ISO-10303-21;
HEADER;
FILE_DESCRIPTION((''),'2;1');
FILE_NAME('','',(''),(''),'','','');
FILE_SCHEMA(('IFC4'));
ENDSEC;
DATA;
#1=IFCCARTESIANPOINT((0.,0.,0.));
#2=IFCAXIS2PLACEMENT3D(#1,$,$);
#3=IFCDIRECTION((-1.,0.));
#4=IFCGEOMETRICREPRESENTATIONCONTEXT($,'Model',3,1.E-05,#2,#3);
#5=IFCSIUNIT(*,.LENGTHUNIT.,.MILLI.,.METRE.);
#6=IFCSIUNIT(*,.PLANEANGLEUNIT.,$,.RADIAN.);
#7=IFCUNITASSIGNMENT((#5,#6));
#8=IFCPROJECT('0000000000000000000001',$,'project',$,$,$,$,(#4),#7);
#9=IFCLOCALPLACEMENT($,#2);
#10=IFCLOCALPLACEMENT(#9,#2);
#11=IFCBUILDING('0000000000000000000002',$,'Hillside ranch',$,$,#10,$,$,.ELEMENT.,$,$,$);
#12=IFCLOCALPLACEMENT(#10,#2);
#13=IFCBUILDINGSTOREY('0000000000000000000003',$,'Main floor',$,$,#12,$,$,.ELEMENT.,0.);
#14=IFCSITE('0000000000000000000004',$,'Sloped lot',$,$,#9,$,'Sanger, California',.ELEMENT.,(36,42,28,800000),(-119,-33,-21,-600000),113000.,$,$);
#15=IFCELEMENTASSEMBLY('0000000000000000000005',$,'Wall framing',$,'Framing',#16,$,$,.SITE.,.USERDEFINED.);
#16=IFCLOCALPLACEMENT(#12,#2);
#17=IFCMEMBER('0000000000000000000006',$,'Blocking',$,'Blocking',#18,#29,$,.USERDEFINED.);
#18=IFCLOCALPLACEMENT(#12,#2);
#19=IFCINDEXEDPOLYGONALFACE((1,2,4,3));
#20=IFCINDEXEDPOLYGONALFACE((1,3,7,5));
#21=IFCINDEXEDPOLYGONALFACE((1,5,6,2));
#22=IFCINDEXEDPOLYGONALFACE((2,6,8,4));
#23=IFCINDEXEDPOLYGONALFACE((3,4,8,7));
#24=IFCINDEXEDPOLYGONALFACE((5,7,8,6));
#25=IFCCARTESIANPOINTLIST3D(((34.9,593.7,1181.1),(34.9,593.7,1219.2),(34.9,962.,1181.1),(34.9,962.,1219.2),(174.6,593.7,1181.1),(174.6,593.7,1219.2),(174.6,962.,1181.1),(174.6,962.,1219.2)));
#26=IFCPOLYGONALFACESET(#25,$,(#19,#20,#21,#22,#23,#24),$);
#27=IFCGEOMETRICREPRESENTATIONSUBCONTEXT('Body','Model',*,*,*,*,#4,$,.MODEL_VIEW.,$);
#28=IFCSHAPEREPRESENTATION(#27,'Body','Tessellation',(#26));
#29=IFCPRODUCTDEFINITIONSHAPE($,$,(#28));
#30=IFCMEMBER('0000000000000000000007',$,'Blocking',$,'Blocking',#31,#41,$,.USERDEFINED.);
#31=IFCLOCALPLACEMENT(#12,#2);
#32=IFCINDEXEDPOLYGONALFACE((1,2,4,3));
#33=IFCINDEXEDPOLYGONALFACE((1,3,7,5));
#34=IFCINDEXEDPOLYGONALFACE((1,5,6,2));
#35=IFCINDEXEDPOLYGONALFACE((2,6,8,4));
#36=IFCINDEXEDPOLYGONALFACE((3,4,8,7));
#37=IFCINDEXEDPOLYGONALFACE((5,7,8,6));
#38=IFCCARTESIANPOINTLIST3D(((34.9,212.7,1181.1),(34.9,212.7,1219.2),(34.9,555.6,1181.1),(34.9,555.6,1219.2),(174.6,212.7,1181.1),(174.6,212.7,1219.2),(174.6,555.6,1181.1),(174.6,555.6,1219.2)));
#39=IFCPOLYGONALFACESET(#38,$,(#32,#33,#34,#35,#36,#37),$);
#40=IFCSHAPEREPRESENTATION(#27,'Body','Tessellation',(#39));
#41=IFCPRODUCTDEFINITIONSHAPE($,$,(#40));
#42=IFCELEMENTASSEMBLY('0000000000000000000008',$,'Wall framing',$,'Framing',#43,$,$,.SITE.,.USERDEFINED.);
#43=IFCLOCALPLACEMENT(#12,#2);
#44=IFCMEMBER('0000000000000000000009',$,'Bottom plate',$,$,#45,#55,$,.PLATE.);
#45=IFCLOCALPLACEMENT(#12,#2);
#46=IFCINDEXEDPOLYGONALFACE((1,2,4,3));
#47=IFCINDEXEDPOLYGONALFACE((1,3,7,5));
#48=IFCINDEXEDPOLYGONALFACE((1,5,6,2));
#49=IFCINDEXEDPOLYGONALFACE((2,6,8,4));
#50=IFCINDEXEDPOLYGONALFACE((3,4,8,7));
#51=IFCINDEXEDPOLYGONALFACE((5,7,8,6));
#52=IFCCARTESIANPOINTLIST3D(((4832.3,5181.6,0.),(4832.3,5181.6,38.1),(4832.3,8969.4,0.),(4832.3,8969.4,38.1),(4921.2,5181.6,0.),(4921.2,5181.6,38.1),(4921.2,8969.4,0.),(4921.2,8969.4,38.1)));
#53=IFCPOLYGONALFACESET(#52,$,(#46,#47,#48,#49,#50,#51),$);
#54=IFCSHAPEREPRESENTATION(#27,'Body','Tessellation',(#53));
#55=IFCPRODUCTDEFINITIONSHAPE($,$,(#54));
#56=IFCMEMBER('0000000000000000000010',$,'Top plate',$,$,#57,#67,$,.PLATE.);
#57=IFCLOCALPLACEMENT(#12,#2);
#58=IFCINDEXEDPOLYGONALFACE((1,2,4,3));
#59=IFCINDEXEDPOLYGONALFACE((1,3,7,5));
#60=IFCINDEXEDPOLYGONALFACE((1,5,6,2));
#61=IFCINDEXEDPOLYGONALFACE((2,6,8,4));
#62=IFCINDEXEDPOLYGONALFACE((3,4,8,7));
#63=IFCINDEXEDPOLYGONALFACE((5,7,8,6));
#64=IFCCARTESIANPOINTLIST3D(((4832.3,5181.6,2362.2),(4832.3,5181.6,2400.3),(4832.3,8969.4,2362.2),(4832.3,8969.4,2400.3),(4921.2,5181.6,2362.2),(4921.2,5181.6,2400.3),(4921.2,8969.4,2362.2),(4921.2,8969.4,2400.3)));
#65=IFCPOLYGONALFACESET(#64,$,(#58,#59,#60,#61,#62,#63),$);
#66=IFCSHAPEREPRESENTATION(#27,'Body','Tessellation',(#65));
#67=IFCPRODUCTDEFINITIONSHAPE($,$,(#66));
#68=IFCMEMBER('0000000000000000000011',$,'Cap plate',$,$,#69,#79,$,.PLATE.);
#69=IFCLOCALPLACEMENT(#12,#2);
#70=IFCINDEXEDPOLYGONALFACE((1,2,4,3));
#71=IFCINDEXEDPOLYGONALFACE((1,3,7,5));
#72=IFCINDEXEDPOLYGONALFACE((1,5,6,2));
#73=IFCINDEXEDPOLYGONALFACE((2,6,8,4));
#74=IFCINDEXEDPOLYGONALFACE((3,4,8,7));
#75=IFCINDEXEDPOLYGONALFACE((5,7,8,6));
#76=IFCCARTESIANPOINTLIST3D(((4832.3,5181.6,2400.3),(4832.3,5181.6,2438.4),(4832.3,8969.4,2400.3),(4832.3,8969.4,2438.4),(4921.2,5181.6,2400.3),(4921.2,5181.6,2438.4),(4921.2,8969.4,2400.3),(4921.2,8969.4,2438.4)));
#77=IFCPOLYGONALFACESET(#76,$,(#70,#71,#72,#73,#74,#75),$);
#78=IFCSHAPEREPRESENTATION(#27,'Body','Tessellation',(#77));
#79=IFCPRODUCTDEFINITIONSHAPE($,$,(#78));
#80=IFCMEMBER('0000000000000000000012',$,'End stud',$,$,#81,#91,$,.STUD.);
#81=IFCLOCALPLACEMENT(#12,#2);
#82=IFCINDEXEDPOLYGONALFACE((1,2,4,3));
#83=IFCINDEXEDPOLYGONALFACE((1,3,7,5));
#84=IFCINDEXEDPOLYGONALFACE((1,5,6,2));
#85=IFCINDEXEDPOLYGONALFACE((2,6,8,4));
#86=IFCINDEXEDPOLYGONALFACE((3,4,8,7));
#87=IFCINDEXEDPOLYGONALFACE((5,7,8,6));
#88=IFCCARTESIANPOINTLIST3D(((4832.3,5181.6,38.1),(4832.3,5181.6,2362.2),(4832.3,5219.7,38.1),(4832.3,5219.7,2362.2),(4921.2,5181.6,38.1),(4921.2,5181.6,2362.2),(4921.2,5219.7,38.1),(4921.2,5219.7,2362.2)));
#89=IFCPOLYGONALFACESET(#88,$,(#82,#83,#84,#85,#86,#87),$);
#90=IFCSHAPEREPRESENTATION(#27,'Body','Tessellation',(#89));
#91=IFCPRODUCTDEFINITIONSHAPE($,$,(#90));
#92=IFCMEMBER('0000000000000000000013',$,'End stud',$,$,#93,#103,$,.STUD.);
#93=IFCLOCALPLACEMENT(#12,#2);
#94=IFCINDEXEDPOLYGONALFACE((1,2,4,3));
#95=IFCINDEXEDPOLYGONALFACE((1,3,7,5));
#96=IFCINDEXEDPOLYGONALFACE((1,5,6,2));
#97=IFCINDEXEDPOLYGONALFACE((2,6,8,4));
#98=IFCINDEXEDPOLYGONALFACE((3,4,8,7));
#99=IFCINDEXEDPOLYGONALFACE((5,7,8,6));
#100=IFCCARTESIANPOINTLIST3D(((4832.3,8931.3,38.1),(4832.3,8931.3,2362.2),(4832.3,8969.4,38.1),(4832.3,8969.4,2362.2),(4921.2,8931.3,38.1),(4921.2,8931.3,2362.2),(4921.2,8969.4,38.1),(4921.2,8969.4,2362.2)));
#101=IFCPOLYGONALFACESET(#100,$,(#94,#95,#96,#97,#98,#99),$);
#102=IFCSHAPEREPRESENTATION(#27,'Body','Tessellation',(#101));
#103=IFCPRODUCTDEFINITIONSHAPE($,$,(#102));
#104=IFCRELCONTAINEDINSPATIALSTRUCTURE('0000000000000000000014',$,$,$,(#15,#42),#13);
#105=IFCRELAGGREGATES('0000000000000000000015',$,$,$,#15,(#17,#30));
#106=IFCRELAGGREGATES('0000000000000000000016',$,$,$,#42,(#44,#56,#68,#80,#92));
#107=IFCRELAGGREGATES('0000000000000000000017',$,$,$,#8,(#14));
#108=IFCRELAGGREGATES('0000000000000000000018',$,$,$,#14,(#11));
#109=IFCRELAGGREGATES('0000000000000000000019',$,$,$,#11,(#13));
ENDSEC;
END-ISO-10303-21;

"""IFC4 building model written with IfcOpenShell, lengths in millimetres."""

from ifc_helpers import new_model, si_unit, direction, frame, origin, origin_with_axes, place, context, subcontext, project, spatial, polyline, outline, extrude, element, aggregate, save


model = new_model("IFC4")

# Units and contexts
model_context = context("Model", 3, precision=1e-05, world=origin(), true_north=direction((-1.0, 0.0)))
body_context = subcontext(model_context, "Body", "Model", "MODEL_VIEW")
ifc_project = project(units=[si_unit("LENGTHUNIT", "METRE", prefix="MILLI"), si_unit("PLANEANGLEUNIT", "RADIAN")], contexts=[model_context])

# Site, building, storey
site_placement = place(None, origin())
site = spatial("IfcSite", under=ifc_project, at=site_placement, Name="Sloped lot", LongName="Sanger, California", CompositionType="ELEMENT", RefLatitude=(36, 42, 28, 800000), RefLongitude=(-119, -33, -21, -600000), RefElevation=113000.0)
building_placement = place(site_placement, origin())
building = spatial("IfcBuilding", under=site, at=building_placement, Name="Hillside ranch", CompositionType="ELEMENT")
storey_placement = place(building_placement, origin())
storey = spatial("IfcBuildingStorey", under=building, at=storey_placement, Name="Main floor", CompositionType="ELEMENT", Elevation=0.0)

# Element assemblies, members
assembly_1_placement = place(storey_placement, origin_with_axes())
assembly_1 = element("IfcElementAssembly", 1, at=assembly_1_placement, inside=storey, Name="Wall framing", ObjectType="Framing", AssemblyPlace="SITE", PredefinedType="USERDEFINED")
member_1_placement = place(storey_placement, origin_with_axes())
member_1 = element("IfcMember", 2, at=member_1_placement, Name="Blocking", ObjectType="Blocking", PredefinedType="USERDEFINED", context=body_context, shape_type="SweptSolid", body=[
    extrude(outline(polyline([(0.0, 0.0), (368.3, 0.0), (368.3, 139.7), (0.0, 139.7), (0.0, 0.0)])), frame((34.9, 962.0, 1181.1), z_axis=(0.0, 0.0, 1.0), x_axis=(0.0, -1.0, 0.0)), (0.0, 0.0, 1.0), 38.1),
])
member_2_placement = place(storey_placement, origin_with_axes())
member_2 = element("IfcMember", 3, at=member_2_placement, Name="Blocking", ObjectType="Blocking", PredefinedType="USERDEFINED", context=body_context, shape_type="SweptSolid", body=[
    extrude(outline(polyline([(0.0, 0.0), (342.9, 0.0), (342.9, 139.7), (0.0, 139.7), (0.0, 0.0)])), frame((34.9, 555.6, 1181.1), z_axis=(0.0, 0.0, 1.0), x_axis=(0.0, -1.0, 0.0)), (0.0, 0.0, 1.0), 38.1),
])
aggregate(assembly_1, [member_1, member_2])
assembly_2_placement = place(storey_placement, origin_with_axes())
assembly_2 = element("IfcElementAssembly", 4, at=assembly_2_placement, inside=storey, Name="Wall framing", ObjectType="Framing", AssemblyPlace="SITE", PredefinedType="USERDEFINED")
member_3_placement = place(storey_placement, origin_with_axes())
member_3 = element("IfcMember", 5, at=member_3_placement, Name="Bottom plate", PredefinedType="PLATE", context=body_context, shape_type="SweptSolid", body=[
    extrude(outline(polyline([(0.0, 0.0), (3787.8, 0.0), (3787.8, 88.9), (0.0, 88.9), (0.0, 0.0)])), frame((4921.2, 5181.6, 0.0), z_axis=(0.0, 0.0, 1.0), x_axis=(0.0, 1.0, 0.0)), (0.0, 0.0, 1.0), 38.1),
])
member_4_placement = place(storey_placement, origin_with_axes())
member_4 = element("IfcMember", 6, at=member_4_placement, Name="Top plate", PredefinedType="PLATE", context=body_context, shape_type="SweptSolid", body=[
    extrude(outline(polyline([(0.0, 0.0), (3787.8, 0.0), (3787.8, 88.9), (0.0, 88.9), (0.0, 0.0)])), frame((4921.2, 5181.6, 2362.2), z_axis=(0.0, 0.0, 1.0), x_axis=(0.0, 1.0, 0.0)), (0.0, 0.0, 1.0), 38.1),
])
member_5_placement = place(storey_placement, origin_with_axes())
member_5 = element("IfcMember", 7, at=member_5_placement, Name="Cap plate", PredefinedType="PLATE", context=body_context, shape_type="SweptSolid", body=[
    extrude(outline(polyline([(0.0, 0.0), (3787.8, 0.0), (3787.8, 88.9), (0.0, 88.9), (0.0, 0.0)])), frame((4921.2, 5181.6, 2400.3), z_axis=(0.0, 0.0, 1.0), x_axis=(0.0, 1.0, 0.0)), (0.0, 0.0, 1.0), 38.1),
])
member_6_placement = place(storey_placement, origin_with_axes())
member_6 = element("IfcMember", 8, at=member_6_placement, Name="End stud", PredefinedType="STUD", context=body_context, shape_type="SweptSolid", body=[
    extrude(outline(polyline([(0.0, 0.0), (38.1, 0.0), (38.1, 88.9), (0.0, 88.9), (0.0, 0.0)])), frame((4921.2, 5181.6, 38.1), z_axis=(0.0, 0.0, 1.0), x_axis=(0.0, 1.0, 0.0)), (0.0, 0.0, 1.0), 2324.1),
])
member_7_placement = place(storey_placement, origin_with_axes())
member_7 = element("IfcMember", 9, at=member_7_placement, Name="End stud", PredefinedType="STUD", context=body_context, shape_type="SweptSolid", body=[
    extrude(outline(polyline([(0.0, 0.0), (38.1, 0.0), (38.1, 88.9), (0.0, 88.9), (0.0, 0.0)])), frame((4921.2, 8931.3, 38.1), z_axis=(0.0, 0.0, 1.0), x_axis=(0.0, 1.0, 0.0)), (0.0, 0.0, 1.0), 2324.1),
])
aggregate(assembly_2, [member_3, member_4, member_5, member_6, member_7])

save(model, "model.ifc")
